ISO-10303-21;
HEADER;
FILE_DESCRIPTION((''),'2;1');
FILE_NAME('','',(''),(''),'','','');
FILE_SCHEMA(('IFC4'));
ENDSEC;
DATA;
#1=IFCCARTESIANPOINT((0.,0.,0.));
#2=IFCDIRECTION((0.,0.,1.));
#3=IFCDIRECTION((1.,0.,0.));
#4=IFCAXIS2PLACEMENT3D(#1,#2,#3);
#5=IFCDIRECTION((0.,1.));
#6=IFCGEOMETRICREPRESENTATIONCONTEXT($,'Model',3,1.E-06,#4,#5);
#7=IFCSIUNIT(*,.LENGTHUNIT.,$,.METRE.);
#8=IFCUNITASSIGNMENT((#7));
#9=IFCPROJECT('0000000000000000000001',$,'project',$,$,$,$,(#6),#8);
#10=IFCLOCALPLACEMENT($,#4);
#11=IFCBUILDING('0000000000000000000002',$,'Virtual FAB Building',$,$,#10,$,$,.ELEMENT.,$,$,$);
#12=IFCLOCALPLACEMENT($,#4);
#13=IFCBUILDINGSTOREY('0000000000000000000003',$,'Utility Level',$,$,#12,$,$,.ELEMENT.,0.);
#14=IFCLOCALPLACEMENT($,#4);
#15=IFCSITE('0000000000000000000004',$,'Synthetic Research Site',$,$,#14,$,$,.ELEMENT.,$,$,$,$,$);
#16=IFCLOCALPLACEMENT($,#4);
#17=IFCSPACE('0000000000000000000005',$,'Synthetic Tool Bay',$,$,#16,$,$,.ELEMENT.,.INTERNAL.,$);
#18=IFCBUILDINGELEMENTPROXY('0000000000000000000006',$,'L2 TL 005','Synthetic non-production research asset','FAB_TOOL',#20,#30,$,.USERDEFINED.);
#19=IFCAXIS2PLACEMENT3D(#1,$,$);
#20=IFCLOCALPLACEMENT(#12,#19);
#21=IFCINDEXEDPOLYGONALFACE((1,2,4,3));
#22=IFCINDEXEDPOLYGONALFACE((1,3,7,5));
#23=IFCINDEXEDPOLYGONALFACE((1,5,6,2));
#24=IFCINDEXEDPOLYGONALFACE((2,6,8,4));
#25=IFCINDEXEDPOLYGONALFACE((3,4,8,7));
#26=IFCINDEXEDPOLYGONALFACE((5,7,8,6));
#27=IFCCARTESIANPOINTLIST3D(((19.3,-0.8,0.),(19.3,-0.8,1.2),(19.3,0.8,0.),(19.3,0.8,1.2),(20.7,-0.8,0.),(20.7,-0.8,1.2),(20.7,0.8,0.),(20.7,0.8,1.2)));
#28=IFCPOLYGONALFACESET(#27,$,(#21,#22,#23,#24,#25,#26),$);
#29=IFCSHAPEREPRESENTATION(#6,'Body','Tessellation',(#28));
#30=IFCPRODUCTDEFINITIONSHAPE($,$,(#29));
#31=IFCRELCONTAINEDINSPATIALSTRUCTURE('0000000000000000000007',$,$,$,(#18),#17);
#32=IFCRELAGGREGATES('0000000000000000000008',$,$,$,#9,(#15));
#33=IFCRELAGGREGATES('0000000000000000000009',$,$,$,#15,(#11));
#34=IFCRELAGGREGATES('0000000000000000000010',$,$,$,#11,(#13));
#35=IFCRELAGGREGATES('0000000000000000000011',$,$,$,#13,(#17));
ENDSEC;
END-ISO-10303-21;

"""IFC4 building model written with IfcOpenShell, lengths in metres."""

from ifc_helpers import new_model, si_unit, direction, frame, origin_with_axes, origin_2d_with_axis, place, context, project, spatial, rectangle, extrude, element, save


model = new_model("IFC4")

# Units and contexts
model_context = context("Model", 3, precision=1e-06, world=origin_with_axes(), true_north=direction((0.0, 1.0)))
ifc_project = project(units=[si_unit("LENGTHUNIT", "METRE")], contexts=[model_context])

# Site, building, storey, space
site_placement = place(None, origin_with_axes())
site = spatial("IfcSite", under=ifc_project, at=site_placement, Name="Synthetic Research Site", CompositionType="ELEMENT")
building_placement = place(None, origin_with_axes())
building = spatial("IfcBuilding", under=site, at=building_placement, Name="Virtual FAB Building", CompositionType="ELEMENT")
storey_placement = place(None, origin_with_axes())
storey = spatial("IfcBuildingStorey", under=building, at=storey_placement, Name="Utility Level", CompositionType="ELEMENT", Elevation=0.0)
space_placement = place(None, origin_with_axes())
space = spatial("IfcSpace", under=storey, at=space_placement, Name="Synthetic Tool Bay", CompositionType="ELEMENT", PredefinedType="INTERNAL")

# Building element proxy
for number, where, z_axis, x_axis, name in (
    (1, (20.0, 0.0, 0.0), (0.0, 0.0, 1.0), (1.0, 0.0, 0.0), "L2 TL 005"),
):
    element("IfcBuildingElementProxy", number, at=place(None, frame(where, z_axis=z_axis, x_axis=x_axis)), inside=space, Name=name, Description="Synthetic non-production research asset", ObjectType="FAB_TOOL", PredefinedType="USERDEFINED", context=model_context, shape_type="SweptSolid", body=[
        extrude(rectangle(XDim=1.4, YDim=1.6, at=origin_2d_with_axis()), origin_with_axes(), (0.0, 0.0, 1.0), 1.2),
    ])

save(model, "model.ifc")
